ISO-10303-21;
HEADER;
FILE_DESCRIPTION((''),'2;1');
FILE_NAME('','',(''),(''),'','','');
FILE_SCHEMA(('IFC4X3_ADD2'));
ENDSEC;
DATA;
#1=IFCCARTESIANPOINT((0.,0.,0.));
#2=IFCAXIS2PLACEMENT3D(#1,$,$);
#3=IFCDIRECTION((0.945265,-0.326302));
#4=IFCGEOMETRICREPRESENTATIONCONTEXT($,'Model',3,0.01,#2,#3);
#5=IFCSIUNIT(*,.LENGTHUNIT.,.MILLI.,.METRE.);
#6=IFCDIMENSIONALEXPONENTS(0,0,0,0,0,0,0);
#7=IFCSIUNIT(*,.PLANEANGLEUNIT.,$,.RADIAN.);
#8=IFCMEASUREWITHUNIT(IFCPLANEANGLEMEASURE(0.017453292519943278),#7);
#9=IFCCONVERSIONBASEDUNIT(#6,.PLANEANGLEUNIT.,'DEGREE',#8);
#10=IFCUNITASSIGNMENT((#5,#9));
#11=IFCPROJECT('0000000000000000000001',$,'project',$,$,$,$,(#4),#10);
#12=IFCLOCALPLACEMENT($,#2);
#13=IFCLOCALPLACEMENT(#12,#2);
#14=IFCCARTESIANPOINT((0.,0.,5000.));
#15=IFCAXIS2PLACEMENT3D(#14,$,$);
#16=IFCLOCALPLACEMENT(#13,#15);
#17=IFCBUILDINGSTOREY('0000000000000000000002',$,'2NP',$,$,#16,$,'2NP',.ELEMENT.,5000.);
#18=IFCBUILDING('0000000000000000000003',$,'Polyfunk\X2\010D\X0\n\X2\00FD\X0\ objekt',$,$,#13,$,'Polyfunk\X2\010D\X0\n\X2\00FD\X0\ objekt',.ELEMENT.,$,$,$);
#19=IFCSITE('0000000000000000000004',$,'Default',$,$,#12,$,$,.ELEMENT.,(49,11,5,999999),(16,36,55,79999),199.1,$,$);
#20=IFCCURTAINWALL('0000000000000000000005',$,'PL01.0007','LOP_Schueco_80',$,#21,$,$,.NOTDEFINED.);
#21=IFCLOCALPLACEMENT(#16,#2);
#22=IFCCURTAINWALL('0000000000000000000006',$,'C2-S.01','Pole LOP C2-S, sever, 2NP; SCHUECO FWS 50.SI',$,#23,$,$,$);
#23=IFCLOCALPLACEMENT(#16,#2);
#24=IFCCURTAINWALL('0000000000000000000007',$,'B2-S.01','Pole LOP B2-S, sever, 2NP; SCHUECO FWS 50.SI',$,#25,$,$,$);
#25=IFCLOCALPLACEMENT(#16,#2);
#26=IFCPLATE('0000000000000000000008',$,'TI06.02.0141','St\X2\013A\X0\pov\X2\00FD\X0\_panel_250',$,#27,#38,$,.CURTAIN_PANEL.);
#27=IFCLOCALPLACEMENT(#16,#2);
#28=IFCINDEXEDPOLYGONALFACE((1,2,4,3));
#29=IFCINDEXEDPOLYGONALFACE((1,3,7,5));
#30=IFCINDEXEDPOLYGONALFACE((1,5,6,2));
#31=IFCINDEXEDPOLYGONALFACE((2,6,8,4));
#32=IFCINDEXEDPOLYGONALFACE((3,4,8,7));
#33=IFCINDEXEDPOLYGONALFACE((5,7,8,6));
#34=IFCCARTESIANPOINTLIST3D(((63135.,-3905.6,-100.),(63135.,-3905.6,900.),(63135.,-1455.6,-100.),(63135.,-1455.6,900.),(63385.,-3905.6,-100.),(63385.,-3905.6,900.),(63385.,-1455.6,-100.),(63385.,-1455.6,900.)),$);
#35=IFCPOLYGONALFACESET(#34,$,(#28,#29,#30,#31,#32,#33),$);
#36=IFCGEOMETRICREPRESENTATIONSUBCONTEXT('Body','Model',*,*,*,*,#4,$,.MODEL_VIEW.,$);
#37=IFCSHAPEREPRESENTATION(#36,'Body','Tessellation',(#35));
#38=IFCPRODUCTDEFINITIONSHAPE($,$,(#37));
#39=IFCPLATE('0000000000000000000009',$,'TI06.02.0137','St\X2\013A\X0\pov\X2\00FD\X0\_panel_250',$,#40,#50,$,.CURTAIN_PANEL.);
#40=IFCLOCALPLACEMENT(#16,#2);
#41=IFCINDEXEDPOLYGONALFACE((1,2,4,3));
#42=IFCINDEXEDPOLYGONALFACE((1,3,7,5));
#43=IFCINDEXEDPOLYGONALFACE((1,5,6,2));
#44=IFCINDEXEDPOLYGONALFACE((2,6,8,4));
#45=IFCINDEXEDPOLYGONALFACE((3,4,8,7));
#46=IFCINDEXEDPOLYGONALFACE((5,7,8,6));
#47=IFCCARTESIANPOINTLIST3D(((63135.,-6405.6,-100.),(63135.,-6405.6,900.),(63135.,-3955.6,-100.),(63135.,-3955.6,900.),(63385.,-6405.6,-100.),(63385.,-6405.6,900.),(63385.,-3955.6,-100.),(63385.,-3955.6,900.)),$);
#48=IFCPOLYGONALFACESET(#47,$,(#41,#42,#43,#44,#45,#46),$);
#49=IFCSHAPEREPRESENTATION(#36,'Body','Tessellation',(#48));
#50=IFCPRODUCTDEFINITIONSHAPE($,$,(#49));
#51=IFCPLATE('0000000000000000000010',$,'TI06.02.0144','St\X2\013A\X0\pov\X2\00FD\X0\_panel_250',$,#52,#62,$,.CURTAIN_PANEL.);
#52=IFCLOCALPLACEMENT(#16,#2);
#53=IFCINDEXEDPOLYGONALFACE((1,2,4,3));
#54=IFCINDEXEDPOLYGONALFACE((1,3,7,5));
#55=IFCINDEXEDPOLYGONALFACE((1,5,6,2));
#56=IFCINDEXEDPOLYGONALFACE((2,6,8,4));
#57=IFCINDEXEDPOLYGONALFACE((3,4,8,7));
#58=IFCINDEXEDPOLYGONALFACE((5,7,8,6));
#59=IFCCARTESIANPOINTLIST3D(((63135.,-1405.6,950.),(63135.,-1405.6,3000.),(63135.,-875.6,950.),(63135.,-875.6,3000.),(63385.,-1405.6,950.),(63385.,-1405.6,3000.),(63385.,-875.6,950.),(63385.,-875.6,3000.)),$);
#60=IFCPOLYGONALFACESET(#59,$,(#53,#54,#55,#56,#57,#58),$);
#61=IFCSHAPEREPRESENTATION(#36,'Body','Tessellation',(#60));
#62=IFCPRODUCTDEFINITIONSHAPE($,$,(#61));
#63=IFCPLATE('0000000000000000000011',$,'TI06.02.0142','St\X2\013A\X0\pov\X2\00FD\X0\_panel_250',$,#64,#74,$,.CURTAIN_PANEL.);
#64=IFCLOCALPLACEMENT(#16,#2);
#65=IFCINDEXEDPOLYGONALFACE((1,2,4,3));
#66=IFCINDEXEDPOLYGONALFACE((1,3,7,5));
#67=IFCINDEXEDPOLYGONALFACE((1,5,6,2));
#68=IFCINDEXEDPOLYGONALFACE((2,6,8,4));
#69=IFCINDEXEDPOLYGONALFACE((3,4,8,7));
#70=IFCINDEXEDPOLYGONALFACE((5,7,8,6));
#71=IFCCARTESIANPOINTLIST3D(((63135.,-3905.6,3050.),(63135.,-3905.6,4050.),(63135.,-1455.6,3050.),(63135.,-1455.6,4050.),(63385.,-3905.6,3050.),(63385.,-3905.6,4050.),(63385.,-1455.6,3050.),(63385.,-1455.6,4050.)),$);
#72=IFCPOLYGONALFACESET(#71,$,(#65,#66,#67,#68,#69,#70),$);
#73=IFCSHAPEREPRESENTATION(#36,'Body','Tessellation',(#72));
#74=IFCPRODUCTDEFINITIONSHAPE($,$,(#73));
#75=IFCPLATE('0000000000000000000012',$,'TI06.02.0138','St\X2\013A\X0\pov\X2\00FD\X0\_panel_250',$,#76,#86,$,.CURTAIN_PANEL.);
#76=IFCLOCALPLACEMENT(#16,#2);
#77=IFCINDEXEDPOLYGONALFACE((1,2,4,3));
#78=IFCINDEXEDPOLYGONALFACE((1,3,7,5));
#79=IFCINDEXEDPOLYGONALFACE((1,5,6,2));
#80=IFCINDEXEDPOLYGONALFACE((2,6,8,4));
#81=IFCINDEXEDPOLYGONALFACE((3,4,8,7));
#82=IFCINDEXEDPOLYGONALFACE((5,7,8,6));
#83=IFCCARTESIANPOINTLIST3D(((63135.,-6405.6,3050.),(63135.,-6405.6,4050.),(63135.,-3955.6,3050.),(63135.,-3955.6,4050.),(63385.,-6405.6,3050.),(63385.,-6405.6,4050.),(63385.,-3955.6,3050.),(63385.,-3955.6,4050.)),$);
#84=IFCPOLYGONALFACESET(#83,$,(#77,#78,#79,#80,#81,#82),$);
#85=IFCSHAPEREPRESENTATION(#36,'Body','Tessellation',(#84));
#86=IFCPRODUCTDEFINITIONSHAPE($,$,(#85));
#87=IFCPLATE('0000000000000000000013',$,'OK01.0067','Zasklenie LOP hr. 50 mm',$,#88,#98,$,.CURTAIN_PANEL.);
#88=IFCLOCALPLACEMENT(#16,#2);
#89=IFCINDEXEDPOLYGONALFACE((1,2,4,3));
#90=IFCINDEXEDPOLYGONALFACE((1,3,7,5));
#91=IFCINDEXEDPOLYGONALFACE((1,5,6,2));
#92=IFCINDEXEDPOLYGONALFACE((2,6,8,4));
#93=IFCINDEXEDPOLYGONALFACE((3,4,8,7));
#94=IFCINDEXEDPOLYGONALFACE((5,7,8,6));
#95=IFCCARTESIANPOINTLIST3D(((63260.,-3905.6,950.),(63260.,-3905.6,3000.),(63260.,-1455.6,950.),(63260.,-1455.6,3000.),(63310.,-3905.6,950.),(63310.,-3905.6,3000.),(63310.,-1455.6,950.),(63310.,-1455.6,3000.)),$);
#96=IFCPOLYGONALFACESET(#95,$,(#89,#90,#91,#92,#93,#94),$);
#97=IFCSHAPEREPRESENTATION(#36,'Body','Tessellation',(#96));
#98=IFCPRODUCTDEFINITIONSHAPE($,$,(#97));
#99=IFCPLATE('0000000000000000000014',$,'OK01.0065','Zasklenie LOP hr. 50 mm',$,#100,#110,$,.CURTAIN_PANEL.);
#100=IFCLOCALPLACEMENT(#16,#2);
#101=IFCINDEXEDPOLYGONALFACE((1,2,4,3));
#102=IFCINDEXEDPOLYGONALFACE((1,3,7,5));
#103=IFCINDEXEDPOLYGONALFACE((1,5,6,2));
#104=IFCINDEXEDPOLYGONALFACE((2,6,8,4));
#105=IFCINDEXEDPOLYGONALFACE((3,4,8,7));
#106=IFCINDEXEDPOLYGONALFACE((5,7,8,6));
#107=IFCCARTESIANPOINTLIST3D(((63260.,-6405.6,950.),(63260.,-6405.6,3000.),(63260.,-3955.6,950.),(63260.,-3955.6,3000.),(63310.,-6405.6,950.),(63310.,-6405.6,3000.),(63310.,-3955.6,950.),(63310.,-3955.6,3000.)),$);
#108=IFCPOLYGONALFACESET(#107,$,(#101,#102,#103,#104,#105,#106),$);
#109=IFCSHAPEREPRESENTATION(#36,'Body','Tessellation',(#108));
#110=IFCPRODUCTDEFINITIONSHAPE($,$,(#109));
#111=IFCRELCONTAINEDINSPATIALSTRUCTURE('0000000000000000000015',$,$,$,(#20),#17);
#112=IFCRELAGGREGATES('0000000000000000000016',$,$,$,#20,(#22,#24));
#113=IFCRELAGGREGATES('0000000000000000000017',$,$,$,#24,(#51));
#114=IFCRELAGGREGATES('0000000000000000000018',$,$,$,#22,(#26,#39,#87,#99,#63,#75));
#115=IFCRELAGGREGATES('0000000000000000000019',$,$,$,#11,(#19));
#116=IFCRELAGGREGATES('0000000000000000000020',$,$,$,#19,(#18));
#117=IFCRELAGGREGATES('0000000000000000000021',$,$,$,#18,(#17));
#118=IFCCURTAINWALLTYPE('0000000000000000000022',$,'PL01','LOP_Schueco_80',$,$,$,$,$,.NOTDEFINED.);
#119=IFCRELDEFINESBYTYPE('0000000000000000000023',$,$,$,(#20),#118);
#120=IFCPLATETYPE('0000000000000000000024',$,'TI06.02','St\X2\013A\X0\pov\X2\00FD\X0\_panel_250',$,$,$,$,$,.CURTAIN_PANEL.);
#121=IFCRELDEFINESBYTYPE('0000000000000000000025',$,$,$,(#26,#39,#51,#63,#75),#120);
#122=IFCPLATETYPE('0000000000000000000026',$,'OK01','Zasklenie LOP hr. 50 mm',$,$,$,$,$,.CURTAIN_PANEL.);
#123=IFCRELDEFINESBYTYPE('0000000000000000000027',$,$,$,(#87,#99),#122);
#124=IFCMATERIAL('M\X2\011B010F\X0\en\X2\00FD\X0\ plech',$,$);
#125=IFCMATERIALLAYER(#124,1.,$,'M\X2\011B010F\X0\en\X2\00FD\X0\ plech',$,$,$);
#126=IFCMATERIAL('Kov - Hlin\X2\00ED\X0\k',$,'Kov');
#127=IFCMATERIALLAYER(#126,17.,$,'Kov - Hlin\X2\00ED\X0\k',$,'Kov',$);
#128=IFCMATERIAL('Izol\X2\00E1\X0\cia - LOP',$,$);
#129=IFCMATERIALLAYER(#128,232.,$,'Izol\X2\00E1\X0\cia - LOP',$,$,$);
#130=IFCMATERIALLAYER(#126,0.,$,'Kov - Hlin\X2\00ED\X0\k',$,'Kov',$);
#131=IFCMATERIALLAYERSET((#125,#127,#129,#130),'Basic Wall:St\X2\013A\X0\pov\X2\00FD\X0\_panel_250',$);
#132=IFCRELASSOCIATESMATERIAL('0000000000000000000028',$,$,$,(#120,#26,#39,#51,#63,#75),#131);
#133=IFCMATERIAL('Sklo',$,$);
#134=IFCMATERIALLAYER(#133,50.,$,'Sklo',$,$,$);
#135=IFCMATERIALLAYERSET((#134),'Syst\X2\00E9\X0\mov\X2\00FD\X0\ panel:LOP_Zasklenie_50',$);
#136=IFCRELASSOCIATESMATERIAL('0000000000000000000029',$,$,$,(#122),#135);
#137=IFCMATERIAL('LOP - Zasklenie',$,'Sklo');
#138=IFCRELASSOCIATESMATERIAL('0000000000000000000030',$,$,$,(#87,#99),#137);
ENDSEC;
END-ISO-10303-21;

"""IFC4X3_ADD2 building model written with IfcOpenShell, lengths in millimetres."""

from ifc_helpers import new_model, entity, si_unit, converted_unit, direction, frame, frame_2d, origin, origin_2d_with_axis, place, context, subcontext, project, spatial, rectangle, extrude, source, transform, mapped, material, layer, layer_set, layer_usage, type_object, type_shapes, element, aggregate, save


model = new_model("IFC4X3_ADD2")

# Units and contexts
model_context = context("Model", 3, precision=0.01, world=origin(), true_north=direction((0.945265, -0.326302)))
body_context = subcontext(model_context, "Body", "Model", "MODEL_VIEW")
ifc_project = project(units=[si_unit("LENGTHUNIT", "METRE", prefix="MILLI"), converted_unit("PLANEANGLEUNIT", "DEGREE", entity("IfcPlaneAngleMeasure", 0.017453292519943278), si_unit("PLANEANGLEUNIT", "RADIAN"), dimensions=[0, 0, 0, 0, 0, 0, 0])], contexts=[model_context])

# Site, building, storey
site_placement = place(None, origin())
site = spatial("IfcSite", under=ifc_project, at=site_placement, Name="Default", CompositionType="ELEMENT", RefLatitude=(49, 11, 5, 999999), RefLongitude=(16, 36, 55, 79999), RefElevation=199.1)
building_placement = place(site_placement, origin())
building = spatial("IfcBuilding", under=site, at=building_placement, Name="Polyfunkčný objekt", LongName="Polyfunkčný objekt", CompositionType="ELEMENT")
storey_placement = place(building_placement, frame((0.0, 0.0, 5000.0)))
storey = spatial("IfcBuildingStorey", under=building, at=storey_placement, Name="2NP", LongName="2NP", CompositionType="ELEMENT", Elevation=5000.0)

# Curtain walls, plates
curtain_wall_type = type_object("IfcCurtainWallType", Name="PL01", Description="LOP_Schueco_80", PredefinedType="NOTDEFINED")
curtain_wall_1_placement = place(storey_placement, frame((0.0, 0.0, -5000.0)))
curtain_wall_1 = element("IfcCurtainWall", 1, at=curtain_wall_1_placement, inside=storey, type_object=curtain_wall_type, Name="PL01.0007", Description="LOP_Schueco_80", PredefinedType="NOTDEFINED")
curtain_wall_2 = element("IfcCurtainWall", 2, Name="C2-S.01", Description="Pole LOP C2-S, sever, 2NP; SCHUECO FWS 50.SI")
curtain_wall_3 = element("IfcCurtainWall", 3, Name="B2-S.01", Description="Pole LOP B2-S, sever, 2NP; SCHUECO FWS 50.SI")
aggregate(curtain_wall_1, [curtain_wall_2, curtain_wall_3])
ifc_material_1 = material(Name="Měďený plech")
ifc_layer_1 = layer(ifc_material_1, 1.0, Name="Měďený plech")
ifc_material_2 = material(Name="Kov - Hliník", Category="Kov")
ifc_layer_2 = layer(ifc_material_2, 17.0, Name="Kov - Hliník", Category="Kov")
ifc_material_3 = material(Name="Izolácia - LOP")
ifc_layer_3 = layer(ifc_material_3, 232.0, Name="Izolácia - LOP")
ifc_layer_4 = layer(ifc_material_2, 0.0, Name="Kov - Hliník", Category="Kov")
ifc_layer_set_1 = layer_set([ifc_layer_1, ifc_layer_2, ifc_layer_3, ifc_layer_4], Name="Basic Wall:Stĺpový_panel_250")
ifc_layer_usage_1 = layer_usage(ifc_layer_set_1, "AXIS2", "NEGATIVE", 125.0)
plate_type_1 = type_object("IfcPlateType", Name="TI06.02", Description="Stĺpový_panel_250", PredefinedType="CURTAIN_PANEL", material=ifc_layer_set_1)
plate_1_placement = place(storey_placement, frame((63260.0, -1455.6, -100.0), z_axis=(0.0, 0.0, 1.0), x_axis=(0.0, -1.0, 0.0)))
plate_1 = element("IfcPlate", 4, at=plate_1_placement, type_object=plate_type_1, material=ifc_layer_usage_1, Name="TI06.02.0141", Description="Stĺpový_panel_250", PredefinedType="CURTAIN_PANEL", context=body_context, shape_type="SweptSolid", body=[
    extrude(rectangle(XDim=250.0, YDim=2450.0, at=frame_2d((0.0, 0.0), x_axis=(1.0, 0.0))), frame((1225.0, 0.0, 0.0), z_axis=(0.0, 0.0, 1.0), x_axis=(0.0, 1.0, 0.0)), (0.0, 0.0, 1.0), 1000.0),
])
ifc_layer_usage_2 = layer_usage(ifc_layer_set_1, "AXIS2", "NEGATIVE", 125.0)
plate_2_placement = place(storey_placement, frame((63260.0, -3955.6, -100.0), z_axis=(0.0, 0.0, 1.0), x_axis=(0.0, -1.0, 0.0)))
plate_2 = element("IfcPlate", 5, at=plate_2_placement, type_object=plate_type_1, material=ifc_layer_usage_2, Name="TI06.02.0137", Description="Stĺpový_panel_250", PredefinedType="CURTAIN_PANEL", context=body_context, shape_type="SweptSolid", body=[
    extrude(rectangle(XDim=250.0, YDim=2450.0, at=frame_2d((0.0, 0.0), x_axis=(1.0, 0.0))), frame((1225.0, 0.0, 0.0), z_axis=(0.0, 0.0, 1.0), x_axis=(0.0, 1.0, 0.0)), (0.0, 0.0, 1.0), 1000.0),
])
ifc_layer_usage_3 = layer_usage(ifc_layer_set_1, "AXIS2", "NEGATIVE", 125.0)
plate_3_placement = place(storey_placement, frame((63260.0, -875.6, 950.0), z_axis=(0.0, 0.0, 1.0), x_axis=(0.0, -1.0, 0.0)))
plate_3 = element("IfcPlate", 6, at=plate_3_placement, type_object=plate_type_1, material=ifc_layer_usage_3, Name="TI06.02.0144", Description="Stĺpový_panel_250", PredefinedType="CURTAIN_PANEL", context=body_context, shape_type="SweptSolid", body=[
    extrude(rectangle(XDim=250.0, YDim=530.0, at=frame_2d((0.0, 0.0), x_axis=(1.0, 0.0))), frame((265.0, 0.0, 0.0), z_axis=(0.0, 0.0, 1.0), x_axis=(0.0, 1.0, 0.0)), (0.0, 0.0, 1.0), 2050.0),
])
aggregate(curtain_wall_3, [plate_3])
ifc_layer_usage_4 = layer_usage(ifc_layer_set_1, "AXIS2", "NEGATIVE", 125.0)
plate_4_placement = place(storey_placement, frame((63260.0, -1455.6, 3050.0), z_axis=(0.0, 0.0, 1.0), x_axis=(0.0, -1.0, 0.0)))
plate_4 = element("IfcPlate", 7, at=plate_4_placement, type_object=plate_type_1, material=ifc_layer_usage_4, Name="TI06.02.0142", Description="Stĺpový_panel_250", PredefinedType="CURTAIN_PANEL", context=body_context, shape_type="SweptSolid", body=[
    extrude(rectangle(XDim=250.0, YDim=2450.0, at=frame_2d((0.0, 0.0), x_axis=(1.0, 0.0))), frame((1225.0, 0.0, 0.0), z_axis=(0.0, 0.0, 1.0), x_axis=(0.0, 1.0, 0.0)), (0.0, 0.0, 1.0), 1000.0),
])
ifc_layer_usage_5 = layer_usage(ifc_layer_set_1, "AXIS2", "NEGATIVE", 125.0)
plate_5_placement = place(storey_placement, frame((63260.0, -3955.6, 3050.0), z_axis=(0.0, 0.0, 1.0), x_axis=(0.0, -1.0, 0.0)))
plate_5 = element("IfcPlate", 8, at=plate_5_placement, type_object=plate_type_1, material=ifc_layer_usage_5, Name="TI06.02.0138", Description="Stĺpový_panel_250", PredefinedType="CURTAIN_PANEL", context=body_context, shape_type="SweptSolid", body=[
    extrude(rectangle(XDim=250.0, YDim=2450.0, at=frame_2d((0.0, 0.0), x_axis=(1.0, 0.0))), frame((1225.0, 0.0, 0.0), z_axis=(0.0, 0.0, 1.0), x_axis=(0.0, 1.0, 0.0)), (0.0, 0.0, 1.0), 1000.0),
])
ifc_material_4 = material(Name="LOP - Zasklenie", Category="Sklo")
ifc_material_5 = material(Name="Sklo")
ifc_layer_5 = layer(ifc_material_5, 50.0, Name="Sklo")
ifc_layer_set_2 = layer_set([ifc_layer_5], Name="Systémový panel:LOP_Zasklenie_50")
plate_type_2 = type_object("IfcPlateType", Name="OK01", Description="Zasklenie LOP hr. 50 mm", PredefinedType="CURTAIN_PANEL", material=ifc_layer_set_2)
shared_shape_1 = source(origin(), body_context, "Body", "SweptSolid", [
    extrude(rectangle(XDim=50.0, YDim=2450.0, at=origin_2d_with_axis()), frame((0.0, 25.0, 0.0), z_axis=(0.0, 0.0, 1.0), x_axis=(0.0, 1.0, 0.0)), (0.0, 0.0, 1.0), 2050.0),
])
type_shapes(plate_type_2, [shared_shape_1])
plate_6_placement = place(curtain_wall_1_placement, frame((63260.0, -2680.6, 5950.0), z_axis=(0.0, 0.0, 1.0), x_axis=(0.0, -1.0, 0.0)))
plate_6 = element("IfcPlate", 9, at=plate_6_placement, type_object=plate_type_2, material=ifc_material_4, Name="OK01.0067", Description="Zasklenie LOP hr. 50 mm", PredefinedType="CURTAIN_PANEL", context=body_context, shape_type="MappedRepresentation", body=[
    mapped(shared_shape_1, transform((0.0, 0.0, 0.0), scale=1.0)),
])
plate_7_placement = place(curtain_wall_1_placement, frame((63260.0, -5180.6, 5950.0), z_axis=(0.0, 0.0, 1.0), x_axis=(0.0, -1.0, 0.0)))
plate_7 = element("IfcPlate", 10, at=plate_7_placement, type_object=plate_type_2, material=ifc_material_4, Name="OK01.0065", Description="Zasklenie LOP hr. 50 mm", PredefinedType="CURTAIN_PANEL", context=body_context, shape_type="MappedRepresentation", body=[
    mapped(shared_shape_1, transform((0.0, 0.0, 0.0), scale=1.0)),
])
aggregate(curtain_wall_2, [plate_1, plate_2, plate_6, plate_7, plate_4, plate_5])

save(model, "model.ifc")
